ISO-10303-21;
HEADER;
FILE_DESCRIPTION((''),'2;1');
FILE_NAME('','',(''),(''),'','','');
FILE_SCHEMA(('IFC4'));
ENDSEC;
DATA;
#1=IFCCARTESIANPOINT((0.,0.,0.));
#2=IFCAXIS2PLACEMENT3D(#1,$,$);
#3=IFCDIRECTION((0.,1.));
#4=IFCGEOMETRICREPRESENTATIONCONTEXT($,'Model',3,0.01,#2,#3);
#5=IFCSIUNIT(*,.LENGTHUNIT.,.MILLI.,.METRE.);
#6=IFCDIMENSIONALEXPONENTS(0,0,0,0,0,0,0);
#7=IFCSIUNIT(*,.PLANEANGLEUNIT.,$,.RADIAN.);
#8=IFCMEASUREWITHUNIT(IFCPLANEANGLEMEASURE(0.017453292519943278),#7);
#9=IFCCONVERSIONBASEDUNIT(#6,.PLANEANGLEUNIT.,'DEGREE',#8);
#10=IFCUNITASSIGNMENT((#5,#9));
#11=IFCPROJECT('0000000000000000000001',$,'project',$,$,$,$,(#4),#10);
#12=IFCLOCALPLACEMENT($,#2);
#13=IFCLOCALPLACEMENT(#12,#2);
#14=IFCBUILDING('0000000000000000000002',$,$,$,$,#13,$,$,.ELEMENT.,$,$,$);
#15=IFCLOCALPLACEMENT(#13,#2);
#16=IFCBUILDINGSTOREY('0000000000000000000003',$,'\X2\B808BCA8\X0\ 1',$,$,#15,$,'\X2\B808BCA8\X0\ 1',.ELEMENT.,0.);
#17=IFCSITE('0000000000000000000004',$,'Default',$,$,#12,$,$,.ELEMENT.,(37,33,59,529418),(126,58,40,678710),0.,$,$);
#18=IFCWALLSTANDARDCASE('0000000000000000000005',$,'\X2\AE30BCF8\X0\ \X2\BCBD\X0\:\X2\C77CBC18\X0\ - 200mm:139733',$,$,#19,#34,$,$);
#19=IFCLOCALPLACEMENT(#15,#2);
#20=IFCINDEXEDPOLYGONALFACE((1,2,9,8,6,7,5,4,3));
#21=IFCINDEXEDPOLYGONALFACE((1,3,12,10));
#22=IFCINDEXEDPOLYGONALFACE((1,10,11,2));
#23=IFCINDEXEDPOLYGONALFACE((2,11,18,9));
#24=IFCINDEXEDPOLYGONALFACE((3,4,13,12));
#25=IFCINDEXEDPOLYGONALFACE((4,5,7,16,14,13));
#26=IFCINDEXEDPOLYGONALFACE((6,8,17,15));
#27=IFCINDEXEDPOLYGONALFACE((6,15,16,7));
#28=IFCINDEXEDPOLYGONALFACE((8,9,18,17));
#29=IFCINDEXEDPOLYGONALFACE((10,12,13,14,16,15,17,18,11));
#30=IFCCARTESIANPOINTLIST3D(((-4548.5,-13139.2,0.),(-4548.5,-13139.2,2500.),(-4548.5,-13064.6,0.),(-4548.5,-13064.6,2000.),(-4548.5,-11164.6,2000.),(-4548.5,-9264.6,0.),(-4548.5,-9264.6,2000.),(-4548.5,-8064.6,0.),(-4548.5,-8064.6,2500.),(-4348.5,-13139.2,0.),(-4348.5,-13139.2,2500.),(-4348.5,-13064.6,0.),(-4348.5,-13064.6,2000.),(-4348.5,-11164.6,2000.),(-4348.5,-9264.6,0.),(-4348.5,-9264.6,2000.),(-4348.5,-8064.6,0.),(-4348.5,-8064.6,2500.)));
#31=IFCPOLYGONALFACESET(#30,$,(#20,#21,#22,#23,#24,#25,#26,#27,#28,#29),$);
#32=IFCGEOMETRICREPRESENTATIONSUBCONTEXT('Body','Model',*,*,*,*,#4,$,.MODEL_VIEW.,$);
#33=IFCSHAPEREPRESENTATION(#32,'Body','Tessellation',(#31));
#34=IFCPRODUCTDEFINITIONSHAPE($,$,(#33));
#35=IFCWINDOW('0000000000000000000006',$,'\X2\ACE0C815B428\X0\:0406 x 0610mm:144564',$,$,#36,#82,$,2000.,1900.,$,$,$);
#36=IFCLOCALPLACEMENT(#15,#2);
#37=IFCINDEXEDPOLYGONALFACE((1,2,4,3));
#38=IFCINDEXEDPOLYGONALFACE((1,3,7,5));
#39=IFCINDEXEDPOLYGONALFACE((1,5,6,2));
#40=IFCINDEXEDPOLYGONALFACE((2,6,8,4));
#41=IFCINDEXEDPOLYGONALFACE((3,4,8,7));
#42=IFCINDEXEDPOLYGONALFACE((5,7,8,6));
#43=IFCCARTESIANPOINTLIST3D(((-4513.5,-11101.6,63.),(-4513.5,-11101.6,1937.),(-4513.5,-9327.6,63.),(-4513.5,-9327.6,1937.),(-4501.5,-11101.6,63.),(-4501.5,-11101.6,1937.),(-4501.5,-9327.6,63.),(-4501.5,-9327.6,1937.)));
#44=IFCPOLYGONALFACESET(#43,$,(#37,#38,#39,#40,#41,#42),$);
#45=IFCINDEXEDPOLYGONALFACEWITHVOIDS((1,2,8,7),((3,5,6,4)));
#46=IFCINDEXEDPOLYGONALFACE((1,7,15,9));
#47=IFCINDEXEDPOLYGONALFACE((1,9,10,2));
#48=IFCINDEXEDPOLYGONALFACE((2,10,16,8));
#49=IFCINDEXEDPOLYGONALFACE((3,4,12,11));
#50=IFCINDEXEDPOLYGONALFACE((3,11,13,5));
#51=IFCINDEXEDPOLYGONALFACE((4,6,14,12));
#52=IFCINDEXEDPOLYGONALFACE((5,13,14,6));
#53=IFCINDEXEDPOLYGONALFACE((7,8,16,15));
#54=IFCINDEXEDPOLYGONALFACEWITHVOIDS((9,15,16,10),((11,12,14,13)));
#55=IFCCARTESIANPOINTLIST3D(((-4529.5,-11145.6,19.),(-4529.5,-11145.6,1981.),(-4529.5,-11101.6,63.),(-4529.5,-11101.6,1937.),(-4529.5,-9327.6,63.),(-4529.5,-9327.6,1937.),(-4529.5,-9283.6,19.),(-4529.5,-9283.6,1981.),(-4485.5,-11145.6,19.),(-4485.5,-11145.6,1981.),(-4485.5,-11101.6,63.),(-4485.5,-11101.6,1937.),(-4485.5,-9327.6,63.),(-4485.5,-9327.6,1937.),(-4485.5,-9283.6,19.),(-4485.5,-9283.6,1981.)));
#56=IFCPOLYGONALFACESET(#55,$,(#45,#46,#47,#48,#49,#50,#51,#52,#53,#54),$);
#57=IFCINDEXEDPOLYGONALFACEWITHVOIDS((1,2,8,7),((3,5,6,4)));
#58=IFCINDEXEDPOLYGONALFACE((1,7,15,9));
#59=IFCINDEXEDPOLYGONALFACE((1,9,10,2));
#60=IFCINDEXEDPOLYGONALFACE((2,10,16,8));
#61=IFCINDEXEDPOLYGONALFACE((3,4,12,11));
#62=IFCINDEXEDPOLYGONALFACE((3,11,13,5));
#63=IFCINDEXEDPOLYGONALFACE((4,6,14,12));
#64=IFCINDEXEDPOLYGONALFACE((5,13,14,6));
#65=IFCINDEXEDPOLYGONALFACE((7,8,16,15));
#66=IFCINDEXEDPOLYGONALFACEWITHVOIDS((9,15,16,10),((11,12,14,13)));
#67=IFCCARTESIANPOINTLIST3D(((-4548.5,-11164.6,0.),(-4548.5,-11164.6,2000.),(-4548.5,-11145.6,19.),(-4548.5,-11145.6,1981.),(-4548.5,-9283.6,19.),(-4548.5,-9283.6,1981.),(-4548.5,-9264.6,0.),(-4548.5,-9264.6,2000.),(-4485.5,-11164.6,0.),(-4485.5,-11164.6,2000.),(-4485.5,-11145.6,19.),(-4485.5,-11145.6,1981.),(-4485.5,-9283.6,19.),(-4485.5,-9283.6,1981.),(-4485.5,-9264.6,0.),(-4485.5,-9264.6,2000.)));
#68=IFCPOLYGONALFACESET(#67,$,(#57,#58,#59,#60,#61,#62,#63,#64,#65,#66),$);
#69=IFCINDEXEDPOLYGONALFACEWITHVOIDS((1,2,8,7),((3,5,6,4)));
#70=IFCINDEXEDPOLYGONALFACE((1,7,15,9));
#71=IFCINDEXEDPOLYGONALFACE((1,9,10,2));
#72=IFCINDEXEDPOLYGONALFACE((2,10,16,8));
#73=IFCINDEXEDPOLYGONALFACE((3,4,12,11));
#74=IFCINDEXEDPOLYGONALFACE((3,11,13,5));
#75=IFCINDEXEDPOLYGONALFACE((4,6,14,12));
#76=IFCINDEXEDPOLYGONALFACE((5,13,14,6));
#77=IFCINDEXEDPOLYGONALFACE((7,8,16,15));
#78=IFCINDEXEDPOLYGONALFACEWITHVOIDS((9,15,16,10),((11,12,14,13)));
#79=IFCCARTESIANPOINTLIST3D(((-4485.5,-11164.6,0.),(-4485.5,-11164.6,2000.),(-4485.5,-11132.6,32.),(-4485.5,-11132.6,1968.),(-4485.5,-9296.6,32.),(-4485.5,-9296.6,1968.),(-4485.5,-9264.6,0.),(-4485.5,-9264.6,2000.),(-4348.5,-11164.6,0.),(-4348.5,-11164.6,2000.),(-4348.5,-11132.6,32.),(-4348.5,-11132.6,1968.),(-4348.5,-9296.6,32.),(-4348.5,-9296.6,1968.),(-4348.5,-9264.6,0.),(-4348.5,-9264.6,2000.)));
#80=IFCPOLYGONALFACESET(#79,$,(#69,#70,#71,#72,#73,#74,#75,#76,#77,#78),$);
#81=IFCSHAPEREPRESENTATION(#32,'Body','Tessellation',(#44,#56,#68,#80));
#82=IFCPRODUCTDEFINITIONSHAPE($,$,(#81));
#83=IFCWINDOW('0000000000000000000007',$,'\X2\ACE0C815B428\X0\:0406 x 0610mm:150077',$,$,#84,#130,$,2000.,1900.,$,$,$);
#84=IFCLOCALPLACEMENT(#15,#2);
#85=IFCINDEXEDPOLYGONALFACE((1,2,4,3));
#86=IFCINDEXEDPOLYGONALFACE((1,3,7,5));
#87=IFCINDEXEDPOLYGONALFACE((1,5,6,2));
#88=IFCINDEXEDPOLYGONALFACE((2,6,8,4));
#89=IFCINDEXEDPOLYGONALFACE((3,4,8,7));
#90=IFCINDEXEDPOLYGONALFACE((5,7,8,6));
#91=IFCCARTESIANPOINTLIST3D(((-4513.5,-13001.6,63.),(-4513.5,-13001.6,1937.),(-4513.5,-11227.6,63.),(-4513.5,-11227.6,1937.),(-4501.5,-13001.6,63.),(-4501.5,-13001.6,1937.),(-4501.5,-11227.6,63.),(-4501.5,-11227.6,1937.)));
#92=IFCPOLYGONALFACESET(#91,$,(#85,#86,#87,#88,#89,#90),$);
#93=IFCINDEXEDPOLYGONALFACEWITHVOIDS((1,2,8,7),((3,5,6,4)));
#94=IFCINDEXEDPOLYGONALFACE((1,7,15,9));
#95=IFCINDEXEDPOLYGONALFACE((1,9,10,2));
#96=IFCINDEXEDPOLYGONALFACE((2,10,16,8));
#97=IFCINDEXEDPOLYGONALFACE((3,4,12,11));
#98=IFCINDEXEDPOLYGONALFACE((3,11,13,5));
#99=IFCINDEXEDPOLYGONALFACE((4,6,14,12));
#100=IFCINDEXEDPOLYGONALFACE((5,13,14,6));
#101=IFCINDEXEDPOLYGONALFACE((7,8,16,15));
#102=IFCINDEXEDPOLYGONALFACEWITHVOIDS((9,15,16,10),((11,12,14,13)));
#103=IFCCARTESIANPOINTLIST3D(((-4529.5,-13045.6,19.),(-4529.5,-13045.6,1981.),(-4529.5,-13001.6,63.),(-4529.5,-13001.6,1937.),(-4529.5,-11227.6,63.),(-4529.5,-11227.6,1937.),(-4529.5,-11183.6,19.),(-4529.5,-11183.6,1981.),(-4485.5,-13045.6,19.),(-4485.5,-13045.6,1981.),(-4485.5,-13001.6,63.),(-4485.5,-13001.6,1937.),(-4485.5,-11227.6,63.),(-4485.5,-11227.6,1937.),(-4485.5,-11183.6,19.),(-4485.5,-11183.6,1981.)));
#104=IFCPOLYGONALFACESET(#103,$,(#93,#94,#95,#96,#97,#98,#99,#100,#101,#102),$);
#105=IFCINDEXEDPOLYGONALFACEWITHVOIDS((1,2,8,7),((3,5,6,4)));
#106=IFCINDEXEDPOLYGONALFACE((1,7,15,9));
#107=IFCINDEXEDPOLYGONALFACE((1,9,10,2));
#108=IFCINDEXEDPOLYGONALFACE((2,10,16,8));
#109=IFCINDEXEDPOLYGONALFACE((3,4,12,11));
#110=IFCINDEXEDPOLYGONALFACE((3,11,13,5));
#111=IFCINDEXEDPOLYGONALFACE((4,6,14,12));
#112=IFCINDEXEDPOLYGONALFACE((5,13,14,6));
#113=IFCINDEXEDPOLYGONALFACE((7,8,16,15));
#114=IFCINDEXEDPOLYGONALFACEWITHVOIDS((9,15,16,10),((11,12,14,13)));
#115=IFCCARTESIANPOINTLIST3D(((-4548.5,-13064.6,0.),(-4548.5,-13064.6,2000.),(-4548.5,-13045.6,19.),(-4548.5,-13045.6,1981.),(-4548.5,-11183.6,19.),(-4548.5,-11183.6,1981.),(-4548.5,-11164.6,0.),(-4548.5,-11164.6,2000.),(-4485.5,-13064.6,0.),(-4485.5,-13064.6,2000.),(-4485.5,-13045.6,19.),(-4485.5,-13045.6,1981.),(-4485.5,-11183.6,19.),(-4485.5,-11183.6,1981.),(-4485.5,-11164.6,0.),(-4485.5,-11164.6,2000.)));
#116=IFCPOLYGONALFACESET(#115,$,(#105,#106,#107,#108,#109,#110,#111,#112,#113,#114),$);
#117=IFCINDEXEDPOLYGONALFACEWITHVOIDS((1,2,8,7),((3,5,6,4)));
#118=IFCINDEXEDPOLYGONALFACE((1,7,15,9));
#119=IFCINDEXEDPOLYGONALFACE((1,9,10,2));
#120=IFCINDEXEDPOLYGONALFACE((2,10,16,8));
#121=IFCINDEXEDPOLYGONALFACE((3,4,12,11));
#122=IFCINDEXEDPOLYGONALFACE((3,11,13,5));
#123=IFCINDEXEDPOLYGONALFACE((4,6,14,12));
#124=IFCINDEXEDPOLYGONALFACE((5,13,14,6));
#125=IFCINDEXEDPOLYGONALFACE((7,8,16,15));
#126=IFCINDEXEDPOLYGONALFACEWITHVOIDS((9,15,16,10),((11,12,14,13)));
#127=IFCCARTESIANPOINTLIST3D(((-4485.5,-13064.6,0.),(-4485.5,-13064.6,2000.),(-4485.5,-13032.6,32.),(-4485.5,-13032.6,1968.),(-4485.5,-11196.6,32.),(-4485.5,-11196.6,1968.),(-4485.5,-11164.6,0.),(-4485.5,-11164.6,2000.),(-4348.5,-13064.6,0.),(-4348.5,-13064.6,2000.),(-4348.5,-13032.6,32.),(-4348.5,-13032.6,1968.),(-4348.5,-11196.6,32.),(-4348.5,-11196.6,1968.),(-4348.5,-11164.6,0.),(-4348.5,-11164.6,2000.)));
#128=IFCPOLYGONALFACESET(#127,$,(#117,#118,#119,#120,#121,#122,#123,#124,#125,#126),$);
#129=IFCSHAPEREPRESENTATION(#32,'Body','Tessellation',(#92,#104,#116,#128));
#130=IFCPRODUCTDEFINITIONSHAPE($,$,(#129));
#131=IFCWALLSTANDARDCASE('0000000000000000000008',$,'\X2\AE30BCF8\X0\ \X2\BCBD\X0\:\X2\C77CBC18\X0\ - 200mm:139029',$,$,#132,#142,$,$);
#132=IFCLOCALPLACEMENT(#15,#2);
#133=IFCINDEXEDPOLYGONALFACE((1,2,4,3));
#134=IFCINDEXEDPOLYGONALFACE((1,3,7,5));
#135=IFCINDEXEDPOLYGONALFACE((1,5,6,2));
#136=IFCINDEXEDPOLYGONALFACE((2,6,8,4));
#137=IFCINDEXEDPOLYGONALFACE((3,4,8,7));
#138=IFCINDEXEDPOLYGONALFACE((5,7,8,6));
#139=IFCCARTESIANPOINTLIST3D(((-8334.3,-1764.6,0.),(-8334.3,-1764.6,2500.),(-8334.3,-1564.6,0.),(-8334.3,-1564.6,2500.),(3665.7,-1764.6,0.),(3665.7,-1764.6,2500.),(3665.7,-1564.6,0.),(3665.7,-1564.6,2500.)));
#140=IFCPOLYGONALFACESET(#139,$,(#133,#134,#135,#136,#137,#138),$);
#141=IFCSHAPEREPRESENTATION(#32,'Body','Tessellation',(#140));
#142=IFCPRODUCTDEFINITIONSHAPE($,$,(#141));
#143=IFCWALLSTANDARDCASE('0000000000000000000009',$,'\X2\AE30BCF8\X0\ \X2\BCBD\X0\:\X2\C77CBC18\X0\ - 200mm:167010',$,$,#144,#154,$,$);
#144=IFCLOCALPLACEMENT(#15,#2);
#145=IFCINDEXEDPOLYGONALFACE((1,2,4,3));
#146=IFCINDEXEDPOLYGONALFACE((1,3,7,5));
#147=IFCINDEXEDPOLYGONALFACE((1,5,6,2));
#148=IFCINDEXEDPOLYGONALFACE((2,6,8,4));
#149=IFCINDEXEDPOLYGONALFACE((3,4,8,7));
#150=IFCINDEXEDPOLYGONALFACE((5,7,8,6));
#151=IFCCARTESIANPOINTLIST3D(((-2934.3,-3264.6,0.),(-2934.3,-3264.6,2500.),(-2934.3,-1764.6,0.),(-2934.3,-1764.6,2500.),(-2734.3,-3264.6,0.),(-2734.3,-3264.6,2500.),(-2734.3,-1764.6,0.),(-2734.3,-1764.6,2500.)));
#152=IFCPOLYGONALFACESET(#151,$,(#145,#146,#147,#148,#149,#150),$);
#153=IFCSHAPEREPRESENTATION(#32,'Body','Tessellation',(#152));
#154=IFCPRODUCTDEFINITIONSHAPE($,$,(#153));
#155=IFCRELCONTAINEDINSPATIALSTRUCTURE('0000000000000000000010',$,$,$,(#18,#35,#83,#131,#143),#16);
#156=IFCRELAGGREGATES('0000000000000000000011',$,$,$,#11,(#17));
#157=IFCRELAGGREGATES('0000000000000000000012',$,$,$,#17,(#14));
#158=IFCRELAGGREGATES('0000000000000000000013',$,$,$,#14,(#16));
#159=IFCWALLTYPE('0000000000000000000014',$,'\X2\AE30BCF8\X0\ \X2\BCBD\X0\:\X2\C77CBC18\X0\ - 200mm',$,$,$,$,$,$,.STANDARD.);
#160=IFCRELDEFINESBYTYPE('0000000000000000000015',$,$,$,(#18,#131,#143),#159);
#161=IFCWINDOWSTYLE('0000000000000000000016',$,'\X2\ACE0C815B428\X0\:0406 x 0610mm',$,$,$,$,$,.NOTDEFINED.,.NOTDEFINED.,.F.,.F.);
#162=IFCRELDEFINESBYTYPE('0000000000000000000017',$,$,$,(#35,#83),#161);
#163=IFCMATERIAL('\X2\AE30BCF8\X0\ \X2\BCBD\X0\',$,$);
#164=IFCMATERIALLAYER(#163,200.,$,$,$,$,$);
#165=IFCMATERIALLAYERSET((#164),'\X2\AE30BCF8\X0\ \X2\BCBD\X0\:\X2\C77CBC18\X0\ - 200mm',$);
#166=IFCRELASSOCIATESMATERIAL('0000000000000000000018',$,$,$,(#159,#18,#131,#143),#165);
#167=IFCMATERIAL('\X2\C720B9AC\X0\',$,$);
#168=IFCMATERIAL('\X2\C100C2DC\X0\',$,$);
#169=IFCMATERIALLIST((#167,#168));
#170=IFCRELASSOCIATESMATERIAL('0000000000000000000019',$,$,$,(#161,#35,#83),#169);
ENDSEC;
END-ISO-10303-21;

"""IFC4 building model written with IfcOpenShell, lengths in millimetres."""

from ifc_helpers import new_model, entity, si_unit, converted_unit, direction, frame, frame_2d, origin, place, context, subcontext, project, spatial, polyline, rectangle, outline, extrude, source, transform, mapped, material, material_list, layer, layer_set, layer_usage, type_object, type_shapes, element, fill, save


model = new_model("IFC4")

# Units and contexts
model_context = context("Model", 3, precision=0.01, world=origin(), true_north=direction((0.0, 1.0)))
body_context = subcontext(model_context, "Body", "Model", "MODEL_VIEW")
ifc_project = project(units=[si_unit("LENGTHUNIT", "METRE", prefix="MILLI"), converted_unit("PLANEANGLEUNIT", "DEGREE", entity("IfcPlaneAngleMeasure", 0.017453292519943278), si_unit("PLANEANGLEUNIT", "RADIAN"), dimensions=[0, 0, 0, 0, 0, 0, 0])], contexts=[model_context])

# Site, building, storey
site_placement = place(None, origin())
site = spatial("IfcSite", under=ifc_project, at=site_placement, Name="Default", CompositionType="ELEMENT", RefLatitude=(37, 33, 59, 529418), RefLongitude=(126, 58, 40, 678710), RefElevation=0.0)
building_placement = place(site_placement, origin())
building = spatial("IfcBuilding", under=site, at=building_placement, CompositionType="ELEMENT")
storey_placement = place(building_placement, origin())
storey = spatial("IfcBuildingStorey", under=building, at=storey_placement, Name="레벨 1", LongName="레벨 1", CompositionType="ELEMENT", Elevation=0.0)

# Wall, openings, windows
ifc_material_1 = material(Name="기본 벽")
ifc_layer_1 = layer(ifc_material_1, 200.0)
ifc_layer_set_1 = layer_set([ifc_layer_1], Name="기본 벽:일반 - 200mm")
ifc_layer_usage_1 = layer_usage(ifc_layer_set_1, "AXIS2", "NEGATIVE", 100.0)
wall_type = type_object("IfcWallType", Name="기본 벽:일반 - 200mm", PredefinedType="STANDARD", material=ifc_layer_set_1)
wall_1_placement = place(storey_placement, frame((-4448.5, -13139.2, 0.0), z_axis=(0.0, 0.0, 1.0), x_axis=(0.0, 1.0, 0.0)))
wall_1 = element("IfcWallStandardCase", 1, at=wall_1_placement, inside=storey, type_object=wall_type, material=ifc_layer_usage_1, Name="기본 벽:일반 - 200mm:139733", context=body_context, shape_type="SweptSolid", body=[
    extrude(rectangle(XDim=5074.5, YDim=200.0, at=frame_2d((2537.3, 0.0), x_axis=(-1.0, 0.0))), origin(), (0.0, 0.0, 1.0), 2500.0),
])
opening_1_placement = place(wall_1_placement, frame((1974.5, -100.0, 0.0)))
opening_1 = element("IfcOpeningElement", 2, at=opening_1_placement, cuts=wall_1, ObjectType="Opening", context=body_context, shape_type="SweptSolid", body=[
    extrude(rectangle(XDim=2000.0, YDim=1900.0, at=frame_2d((1000.0, 950.0), x_axis=(1.0, 0.0))), frame((0.0, 0.0, 0.0), z_axis=(0.0, 1.0, 0.0), x_axis=(0.0, 0.0, 1.0)), (0.0, 0.0, 1.0), 200.0),
])
opening_2_placement = place(wall_1_placement, frame((74.5, -100.0, 0.0)))
opening_2 = element("IfcOpeningElement", 3, at=opening_2_placement, cuts=wall_1, ObjectType="Opening", context=body_context, shape_type="SweptSolid", body=[
    extrude(rectangle(XDim=2000.0, YDim=1900.0, at=frame_2d((1000.0, 950.0), x_axis=(1.0, 0.0))), frame((0.0, 0.0, 0.0), z_axis=(0.0, 1.0, 0.0), x_axis=(0.0, 0.0, 1.0)), (0.0, 0.0, 1.0), 200.0),
])
ifc_material_2 = material(Name="유리")
ifc_material_3 = material(Name="섀시")
ifc_material_list = material_list([ifc_material_2, ifc_material_3])
window_style = type_object("IfcWindowStyle", Name="고정됨:0406 x 0610mm", ConstructionType="NOTDEFINED", OperationType="NOTDEFINED", ParameterTakesPrecedence=False, Sizeable=False, material=ifc_material_list)
shared_shape = source(origin(), body_context, "Body", "SweptSolid", [
    extrude(rectangle(XDim=12.0, YDim=1774.0, at=frame_2d((0.0, 0.0), x_axis=(1.0, 0.0))), frame((950.0, 159.0, 63.0), z_axis=(0.0, 0.0, 1.0), x_axis=(0.0, -1.0, 0.0)), (0.0, 0.0, 1.0), 1874.0),
    extrude(outline(polyline([(-931.0, -981.0), (931.0, -981.0), (931.0, 981.0), (-931.0, 981.0), (-931.0, -981.0)]), holes=[polyline([(-887.0, -937.0), (-887.0, 937.0), (887.0, 937.0), (887.0, -937.0), (-887.0, -937.0)])]), frame((950.0, 137.0, 1000.0), z_axis=(0.0, 1.0, 0.0), x_axis=(1.0, 0.0, 0.0)), (0.0, 0.0, 1.0), 44.0),
    extrude(outline(polyline([(-950.0, -1000.0), (950.0, -1000.0), (950.0, 1000.0), (-950.0, 1000.0), (-950.0, -1000.0)]), holes=[polyline([(-931.0, -981.0), (-931.0, 981.0), (931.0, 981.0), (931.0, -981.0), (-931.0, -981.0)])]), frame((950.0, 137.0, 1000.0), z_axis=(0.0, 1.0, 0.0), x_axis=(1.0, 0.0, 0.0)), (0.0, 0.0, 1.0), 63.0),
    extrude(outline(polyline([(-950.0, -1000.0), (950.0, -1000.0), (950.0, 1000.0), (-950.0, 1000.0), (-950.0, -1000.0)]), holes=[polyline([(-918.0, -968.0), (-918.0, 968.0), (918.0, 968.0), (918.0, -968.0), (-918.0, -968.0)])]), frame((950.0, 0.0, 1000.0), z_axis=(0.0, 1.0, 0.0), x_axis=(1.0, 0.0, 0.0)), (0.0, 0.0, 1.0), 137.0),
])
type_shapes(window_style, [shared_shape])
window_1_placement = place(opening_1_placement, origin())
window_1 = element("IfcWindow", 4, at=window_1_placement, inside=storey, type_object=window_style, material=ifc_material_list, Name="고정됨:0406 x 0610mm:144564", OverallHeight=2000.0, OverallWidth=1900.0, context=body_context, shape_type="MappedRepresentation", body=[
    mapped(shared_shape, transform((0.0, 0.0, 0.0), scale=1.0)),
])
fill(opening_1, window_1)
window_2_placement = place(opening_2_placement, origin())
window_2 = element("IfcWindow", 5, at=window_2_placement, inside=storey, type_object=window_style, material=ifc_material_list, Name="고정됨:0406 x 0610mm:150077", OverallHeight=2000.0, OverallWidth=1900.0, context=body_context, shape_type="MappedRepresentation", body=[
    mapped(shared_shape, transform((0.0, 0.0, 0.0), scale=1.0)),
])
fill(opening_2, window_2)

# Walls
ifc_layer_usage_2 = layer_usage(ifc_layer_set_1, "AXIS2", "NEGATIVE", 100.0)
wall_2_placement = place(storey_placement, frame((-8334.3, -1664.6, 0.0)))
element("IfcWallStandardCase", 6, at=wall_2_placement, inside=storey, type_object=wall_type, material=ifc_layer_usage_2, Name="기본 벽:일반 - 200mm:139029", context=body_context, shape_type="SweptSolid", body=[
    extrude(rectangle(XDim=12000.0, YDim=200.0, at=frame_2d((6000.0, 0.0), x_axis=(-1.0, 0.0))), origin(), (0.0, 0.0, 1.0), 2500.0),
])
ifc_layer_usage_3 = layer_usage(ifc_layer_set_1, "AXIS2", "NEGATIVE", 100.0)
wall_3_placement = place(storey_placement, frame((-2834.3, -1764.6, 0.0), z_axis=(0.0, 0.0, 1.0), x_axis=(0.0, -1.0, 0.0)))
element("IfcWallStandardCase", 7, at=wall_3_placement, inside=storey, type_object=wall_type, material=ifc_layer_usage_3, Name="기본 벽:일반 - 200mm:167010", context=body_context, shape_type="SweptSolid", body=[
    extrude(rectangle(XDim=1500.0, YDim=200.0, at=frame_2d((750.0, 0.0), x_axis=(-1.0, 0.0))), origin(), (0.0, 0.0, 1.0), 2500.0),
])

save(model, "model.ifc")
